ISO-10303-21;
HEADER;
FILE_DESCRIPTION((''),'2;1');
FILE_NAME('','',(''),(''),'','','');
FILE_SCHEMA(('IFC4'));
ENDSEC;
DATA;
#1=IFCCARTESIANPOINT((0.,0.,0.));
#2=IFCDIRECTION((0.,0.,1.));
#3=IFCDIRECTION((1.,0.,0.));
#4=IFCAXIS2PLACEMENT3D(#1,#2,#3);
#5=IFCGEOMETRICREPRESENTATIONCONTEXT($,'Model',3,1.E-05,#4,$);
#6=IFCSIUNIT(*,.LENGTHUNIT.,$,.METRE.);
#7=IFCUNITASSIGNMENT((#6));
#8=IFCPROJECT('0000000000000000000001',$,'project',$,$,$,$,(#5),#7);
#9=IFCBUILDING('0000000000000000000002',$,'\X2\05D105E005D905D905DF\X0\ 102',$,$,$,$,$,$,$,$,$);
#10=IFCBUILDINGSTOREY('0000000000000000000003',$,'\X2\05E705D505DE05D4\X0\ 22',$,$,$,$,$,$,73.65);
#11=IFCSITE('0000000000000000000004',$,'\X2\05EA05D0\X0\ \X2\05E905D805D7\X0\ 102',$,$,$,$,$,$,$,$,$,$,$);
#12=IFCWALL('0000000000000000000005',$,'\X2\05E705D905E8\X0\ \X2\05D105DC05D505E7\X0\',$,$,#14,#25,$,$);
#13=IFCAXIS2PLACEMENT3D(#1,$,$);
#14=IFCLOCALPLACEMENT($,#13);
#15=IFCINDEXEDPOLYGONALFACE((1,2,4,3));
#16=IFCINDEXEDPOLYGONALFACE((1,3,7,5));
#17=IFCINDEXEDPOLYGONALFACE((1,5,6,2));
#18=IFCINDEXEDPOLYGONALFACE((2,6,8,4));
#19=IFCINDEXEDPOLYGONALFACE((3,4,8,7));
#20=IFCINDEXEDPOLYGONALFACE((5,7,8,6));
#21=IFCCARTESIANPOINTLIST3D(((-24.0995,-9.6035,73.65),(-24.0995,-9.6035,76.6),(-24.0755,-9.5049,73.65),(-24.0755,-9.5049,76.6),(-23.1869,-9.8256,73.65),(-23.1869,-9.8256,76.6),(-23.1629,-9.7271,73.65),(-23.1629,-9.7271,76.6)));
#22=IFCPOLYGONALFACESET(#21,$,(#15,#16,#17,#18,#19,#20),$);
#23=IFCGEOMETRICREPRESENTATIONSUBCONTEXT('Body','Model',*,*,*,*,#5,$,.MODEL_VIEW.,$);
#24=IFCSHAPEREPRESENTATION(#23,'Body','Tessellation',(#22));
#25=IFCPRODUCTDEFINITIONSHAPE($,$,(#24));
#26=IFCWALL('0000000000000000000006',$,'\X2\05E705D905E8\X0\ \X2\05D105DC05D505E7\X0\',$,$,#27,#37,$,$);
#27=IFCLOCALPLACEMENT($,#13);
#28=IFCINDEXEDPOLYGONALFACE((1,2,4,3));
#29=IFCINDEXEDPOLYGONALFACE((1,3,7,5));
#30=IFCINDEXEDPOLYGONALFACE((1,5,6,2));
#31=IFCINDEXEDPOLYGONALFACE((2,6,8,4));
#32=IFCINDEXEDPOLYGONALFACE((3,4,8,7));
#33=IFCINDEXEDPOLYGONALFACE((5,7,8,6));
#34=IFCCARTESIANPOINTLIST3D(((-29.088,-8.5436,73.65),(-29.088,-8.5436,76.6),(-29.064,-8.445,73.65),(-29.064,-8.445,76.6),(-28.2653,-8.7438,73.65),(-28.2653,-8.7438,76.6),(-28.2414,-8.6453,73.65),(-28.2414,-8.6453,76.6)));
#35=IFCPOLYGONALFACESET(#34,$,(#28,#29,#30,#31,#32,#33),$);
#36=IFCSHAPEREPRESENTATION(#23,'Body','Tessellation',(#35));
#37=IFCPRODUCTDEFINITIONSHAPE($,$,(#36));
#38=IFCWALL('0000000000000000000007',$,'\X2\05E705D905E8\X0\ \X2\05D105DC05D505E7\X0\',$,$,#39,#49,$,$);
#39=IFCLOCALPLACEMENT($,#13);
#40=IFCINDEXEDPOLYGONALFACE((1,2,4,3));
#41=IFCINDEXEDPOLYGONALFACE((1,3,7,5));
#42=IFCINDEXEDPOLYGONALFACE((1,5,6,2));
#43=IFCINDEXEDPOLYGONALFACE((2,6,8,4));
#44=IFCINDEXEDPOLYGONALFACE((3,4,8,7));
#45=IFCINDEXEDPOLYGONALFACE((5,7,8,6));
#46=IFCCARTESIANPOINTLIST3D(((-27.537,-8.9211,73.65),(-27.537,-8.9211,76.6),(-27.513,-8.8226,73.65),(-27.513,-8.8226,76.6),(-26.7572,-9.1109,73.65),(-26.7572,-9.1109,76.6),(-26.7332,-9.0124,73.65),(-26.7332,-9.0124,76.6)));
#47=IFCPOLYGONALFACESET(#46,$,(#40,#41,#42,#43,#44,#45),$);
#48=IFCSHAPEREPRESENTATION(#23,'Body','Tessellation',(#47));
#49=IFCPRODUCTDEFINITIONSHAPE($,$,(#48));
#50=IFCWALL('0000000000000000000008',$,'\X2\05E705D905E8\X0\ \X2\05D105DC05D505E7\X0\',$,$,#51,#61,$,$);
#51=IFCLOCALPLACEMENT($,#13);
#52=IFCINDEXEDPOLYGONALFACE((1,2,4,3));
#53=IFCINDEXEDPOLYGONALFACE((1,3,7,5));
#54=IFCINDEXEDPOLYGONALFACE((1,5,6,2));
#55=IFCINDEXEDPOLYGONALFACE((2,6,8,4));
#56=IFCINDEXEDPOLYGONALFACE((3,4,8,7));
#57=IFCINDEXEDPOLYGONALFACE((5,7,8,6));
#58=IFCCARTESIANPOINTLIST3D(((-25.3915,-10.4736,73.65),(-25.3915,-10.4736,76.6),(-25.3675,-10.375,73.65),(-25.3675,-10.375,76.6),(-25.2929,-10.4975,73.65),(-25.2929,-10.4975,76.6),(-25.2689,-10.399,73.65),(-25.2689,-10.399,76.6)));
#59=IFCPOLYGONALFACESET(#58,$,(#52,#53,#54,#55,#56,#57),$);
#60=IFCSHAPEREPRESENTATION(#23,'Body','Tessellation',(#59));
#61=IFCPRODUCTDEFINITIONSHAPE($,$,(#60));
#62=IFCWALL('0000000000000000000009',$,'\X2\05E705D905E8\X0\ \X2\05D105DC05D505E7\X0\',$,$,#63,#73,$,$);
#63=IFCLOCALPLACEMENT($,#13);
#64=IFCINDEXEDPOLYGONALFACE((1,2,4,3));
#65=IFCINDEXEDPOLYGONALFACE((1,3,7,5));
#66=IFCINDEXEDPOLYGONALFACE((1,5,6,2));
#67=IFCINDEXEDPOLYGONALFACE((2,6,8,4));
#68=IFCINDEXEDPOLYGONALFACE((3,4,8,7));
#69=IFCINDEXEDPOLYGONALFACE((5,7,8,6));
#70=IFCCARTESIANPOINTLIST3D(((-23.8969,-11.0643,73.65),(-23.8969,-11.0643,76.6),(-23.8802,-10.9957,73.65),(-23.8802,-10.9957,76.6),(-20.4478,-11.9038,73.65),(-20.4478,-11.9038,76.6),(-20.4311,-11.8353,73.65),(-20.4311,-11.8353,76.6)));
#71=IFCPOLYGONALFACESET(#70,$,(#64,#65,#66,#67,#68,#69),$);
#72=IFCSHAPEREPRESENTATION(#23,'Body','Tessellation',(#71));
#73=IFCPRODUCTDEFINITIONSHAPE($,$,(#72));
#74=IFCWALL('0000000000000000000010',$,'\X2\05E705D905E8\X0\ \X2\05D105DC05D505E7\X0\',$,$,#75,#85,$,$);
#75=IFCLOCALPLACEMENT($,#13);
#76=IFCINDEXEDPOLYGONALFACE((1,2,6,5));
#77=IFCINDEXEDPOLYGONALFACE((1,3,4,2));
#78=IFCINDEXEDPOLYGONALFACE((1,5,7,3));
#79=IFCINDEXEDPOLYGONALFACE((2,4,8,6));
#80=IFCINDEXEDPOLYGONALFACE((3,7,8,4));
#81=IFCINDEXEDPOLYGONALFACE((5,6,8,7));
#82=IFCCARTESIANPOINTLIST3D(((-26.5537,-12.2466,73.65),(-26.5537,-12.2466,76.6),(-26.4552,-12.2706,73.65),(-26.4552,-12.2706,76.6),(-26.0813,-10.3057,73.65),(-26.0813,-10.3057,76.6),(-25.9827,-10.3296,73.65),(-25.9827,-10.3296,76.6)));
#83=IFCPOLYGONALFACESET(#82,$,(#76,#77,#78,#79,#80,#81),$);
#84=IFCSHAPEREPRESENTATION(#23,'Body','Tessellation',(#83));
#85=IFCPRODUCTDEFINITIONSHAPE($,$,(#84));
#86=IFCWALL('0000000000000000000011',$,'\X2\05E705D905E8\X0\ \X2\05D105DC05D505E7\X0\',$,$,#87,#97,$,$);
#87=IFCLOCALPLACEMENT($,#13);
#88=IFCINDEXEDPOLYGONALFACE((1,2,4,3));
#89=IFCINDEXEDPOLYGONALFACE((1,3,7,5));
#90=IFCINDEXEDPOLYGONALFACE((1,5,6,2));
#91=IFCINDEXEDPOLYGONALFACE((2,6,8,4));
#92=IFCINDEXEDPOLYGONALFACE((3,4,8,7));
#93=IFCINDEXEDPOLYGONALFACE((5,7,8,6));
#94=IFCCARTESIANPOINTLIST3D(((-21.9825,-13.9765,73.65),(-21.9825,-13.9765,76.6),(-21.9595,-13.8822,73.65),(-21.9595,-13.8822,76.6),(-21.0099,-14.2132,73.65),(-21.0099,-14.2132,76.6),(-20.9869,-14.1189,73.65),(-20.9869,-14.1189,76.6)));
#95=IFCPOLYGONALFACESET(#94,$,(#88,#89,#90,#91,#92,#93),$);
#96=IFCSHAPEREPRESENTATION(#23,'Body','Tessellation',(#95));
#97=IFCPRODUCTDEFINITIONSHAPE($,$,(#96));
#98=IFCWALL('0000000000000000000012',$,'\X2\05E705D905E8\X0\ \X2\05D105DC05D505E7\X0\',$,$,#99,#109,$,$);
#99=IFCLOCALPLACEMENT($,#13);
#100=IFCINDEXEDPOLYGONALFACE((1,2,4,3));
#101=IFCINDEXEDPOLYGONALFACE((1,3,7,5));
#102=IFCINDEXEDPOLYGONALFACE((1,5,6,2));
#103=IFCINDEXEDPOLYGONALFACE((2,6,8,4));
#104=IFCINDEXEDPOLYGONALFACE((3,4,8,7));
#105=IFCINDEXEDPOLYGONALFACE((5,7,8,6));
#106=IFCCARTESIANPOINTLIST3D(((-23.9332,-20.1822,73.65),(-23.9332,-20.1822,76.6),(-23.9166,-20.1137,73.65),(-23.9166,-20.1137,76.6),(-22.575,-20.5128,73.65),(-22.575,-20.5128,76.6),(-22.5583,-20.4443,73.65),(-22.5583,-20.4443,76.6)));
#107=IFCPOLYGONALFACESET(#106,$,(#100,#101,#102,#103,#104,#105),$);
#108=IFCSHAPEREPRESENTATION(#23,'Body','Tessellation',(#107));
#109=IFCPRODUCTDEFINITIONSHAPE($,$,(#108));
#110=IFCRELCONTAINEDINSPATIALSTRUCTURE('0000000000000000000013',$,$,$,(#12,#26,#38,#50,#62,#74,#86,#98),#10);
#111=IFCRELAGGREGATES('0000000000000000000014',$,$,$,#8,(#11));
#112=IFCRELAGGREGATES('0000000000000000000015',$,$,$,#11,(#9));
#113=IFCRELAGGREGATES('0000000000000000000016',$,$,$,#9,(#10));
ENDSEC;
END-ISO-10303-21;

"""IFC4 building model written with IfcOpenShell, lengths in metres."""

from ifc_helpers import new_model, si_unit, frame, origin_with_axes, context, subcontext, project, spatial, polyline, outline, extrude, element, save


model = new_model("IFC4")

# Units and contexts
model_context = context("Model", 3, precision=1e-05, world=origin_with_axes())
body_context = subcontext(model_context, "Body", "Model", "MODEL_VIEW")
ifc_project = project(units=[si_unit("LENGTHUNIT", "METRE")], contexts=[model_context])

# Site, building, storey
site = spatial("IfcSite", under=ifc_project, Name="תא שטח 102")
building = spatial("IfcBuilding", under=site, Name="בניין 102")
storey = spatial("IfcBuildingStorey", under=building, Name="קומה 22", Elevation=73.65)

# Walls
element("IfcWall", 1, inside=storey, Name="קיר בלוק", context=body_context, shape_type="SweptSolid", body=[
    extrude(outline(polyline([(-24.0755, -9.5049), (-24.0995, -9.6035), (-23.1869, -9.8256), (-23.1629, -9.7271), (-24.0755, -9.5049)])), frame((0.0, 0.0, 73.65)), (0.0, 0.0, 1.0), 2.95),
])
element("IfcWall", 2, inside=storey, Name="קיר בלוק", context=body_context, shape_type="SweptSolid", body=[
    extrude(outline(polyline([(-29.088, -8.5436), (-28.2653, -8.7438), (-28.2414, -8.6453), (-29.064, -8.445), (-29.088, -8.5436)])), frame((0.0, 0.0, 73.65)), (0.0, 0.0, 1.0), 2.95),
])
element("IfcWall", 3, inside=storey, Name="קיר בלוק", context=body_context, shape_type="SweptSolid", body=[
    extrude(outline(polyline([(-27.513, -8.8226), (-27.537, -8.9211), (-26.7572, -9.1109), (-26.7332, -9.0124), (-27.513, -8.8226)])), frame((0.0, 0.0, 73.65)), (0.0, 0.0, 1.0), 2.95),
])
element("IfcWall", 4, inside=storey, Name="קיר בלוק", context=body_context, shape_type="SweptSolid", body=[
    extrude(outline(polyline([(-25.3915, -10.4736), (-25.2929, -10.4975), (-25.2689, -10.399), (-25.3675, -10.375), (-25.3915, -10.4736)])), frame((0.0, 0.0, 73.65)), (0.0, 0.0, 1.0), 2.95),
])
element("IfcWall", 5, inside=storey, Name="קיר בלוק", context=body_context, shape_type="SweptSolid", body=[
    extrude(outline(polyline([(-20.4478, -11.9038), (-20.4311, -11.8353), (-23.8802, -10.9957), (-23.8969, -11.0643), (-20.4478, -11.9038)])), frame((0.0, 0.0, 73.65)), (0.0, 0.0, 1.0), 2.95),
])
element("IfcWall", 6, inside=storey, Name="קיר בלוק", context=body_context, shape_type="SweptSolid", body=[
    extrude(outline(polyline([(-26.5537, -12.2466), (-26.4552, -12.2706), (-25.9827, -10.3296), (-26.0813, -10.3057), (-26.5537, -12.2466)])), frame((0.0, 0.0, 73.65)), (0.0, 0.0, 1.0), 2.95),
])
element("IfcWall", 7, inside=storey, Name="קיר בלוק", context=body_context, shape_type="SweptSolid", body=[
    extrude(outline(polyline([(-21.9595, -13.8822), (-21.9825, -13.9765), (-21.0099, -14.2132), (-20.9869, -14.1189), (-21.9595, -13.8822)])), frame((0.0, 0.0, 73.65)), (0.0, 0.0, 1.0), 2.95),
])
element("IfcWall", 8, inside=storey, Name="קיר בלוק", context=body_context, shape_type="SweptSolid", body=[
    extrude(outline(polyline([(-22.5583, -20.4443), (-23.9166, -20.1137), (-23.9332, -20.1822), (-22.575, -20.5128), (-22.5583, -20.4443)])), frame((0.0, 0.0, 73.65)), (0.0, 0.0, 1.0), 2.95),
])

save(model, "model.ifc")
